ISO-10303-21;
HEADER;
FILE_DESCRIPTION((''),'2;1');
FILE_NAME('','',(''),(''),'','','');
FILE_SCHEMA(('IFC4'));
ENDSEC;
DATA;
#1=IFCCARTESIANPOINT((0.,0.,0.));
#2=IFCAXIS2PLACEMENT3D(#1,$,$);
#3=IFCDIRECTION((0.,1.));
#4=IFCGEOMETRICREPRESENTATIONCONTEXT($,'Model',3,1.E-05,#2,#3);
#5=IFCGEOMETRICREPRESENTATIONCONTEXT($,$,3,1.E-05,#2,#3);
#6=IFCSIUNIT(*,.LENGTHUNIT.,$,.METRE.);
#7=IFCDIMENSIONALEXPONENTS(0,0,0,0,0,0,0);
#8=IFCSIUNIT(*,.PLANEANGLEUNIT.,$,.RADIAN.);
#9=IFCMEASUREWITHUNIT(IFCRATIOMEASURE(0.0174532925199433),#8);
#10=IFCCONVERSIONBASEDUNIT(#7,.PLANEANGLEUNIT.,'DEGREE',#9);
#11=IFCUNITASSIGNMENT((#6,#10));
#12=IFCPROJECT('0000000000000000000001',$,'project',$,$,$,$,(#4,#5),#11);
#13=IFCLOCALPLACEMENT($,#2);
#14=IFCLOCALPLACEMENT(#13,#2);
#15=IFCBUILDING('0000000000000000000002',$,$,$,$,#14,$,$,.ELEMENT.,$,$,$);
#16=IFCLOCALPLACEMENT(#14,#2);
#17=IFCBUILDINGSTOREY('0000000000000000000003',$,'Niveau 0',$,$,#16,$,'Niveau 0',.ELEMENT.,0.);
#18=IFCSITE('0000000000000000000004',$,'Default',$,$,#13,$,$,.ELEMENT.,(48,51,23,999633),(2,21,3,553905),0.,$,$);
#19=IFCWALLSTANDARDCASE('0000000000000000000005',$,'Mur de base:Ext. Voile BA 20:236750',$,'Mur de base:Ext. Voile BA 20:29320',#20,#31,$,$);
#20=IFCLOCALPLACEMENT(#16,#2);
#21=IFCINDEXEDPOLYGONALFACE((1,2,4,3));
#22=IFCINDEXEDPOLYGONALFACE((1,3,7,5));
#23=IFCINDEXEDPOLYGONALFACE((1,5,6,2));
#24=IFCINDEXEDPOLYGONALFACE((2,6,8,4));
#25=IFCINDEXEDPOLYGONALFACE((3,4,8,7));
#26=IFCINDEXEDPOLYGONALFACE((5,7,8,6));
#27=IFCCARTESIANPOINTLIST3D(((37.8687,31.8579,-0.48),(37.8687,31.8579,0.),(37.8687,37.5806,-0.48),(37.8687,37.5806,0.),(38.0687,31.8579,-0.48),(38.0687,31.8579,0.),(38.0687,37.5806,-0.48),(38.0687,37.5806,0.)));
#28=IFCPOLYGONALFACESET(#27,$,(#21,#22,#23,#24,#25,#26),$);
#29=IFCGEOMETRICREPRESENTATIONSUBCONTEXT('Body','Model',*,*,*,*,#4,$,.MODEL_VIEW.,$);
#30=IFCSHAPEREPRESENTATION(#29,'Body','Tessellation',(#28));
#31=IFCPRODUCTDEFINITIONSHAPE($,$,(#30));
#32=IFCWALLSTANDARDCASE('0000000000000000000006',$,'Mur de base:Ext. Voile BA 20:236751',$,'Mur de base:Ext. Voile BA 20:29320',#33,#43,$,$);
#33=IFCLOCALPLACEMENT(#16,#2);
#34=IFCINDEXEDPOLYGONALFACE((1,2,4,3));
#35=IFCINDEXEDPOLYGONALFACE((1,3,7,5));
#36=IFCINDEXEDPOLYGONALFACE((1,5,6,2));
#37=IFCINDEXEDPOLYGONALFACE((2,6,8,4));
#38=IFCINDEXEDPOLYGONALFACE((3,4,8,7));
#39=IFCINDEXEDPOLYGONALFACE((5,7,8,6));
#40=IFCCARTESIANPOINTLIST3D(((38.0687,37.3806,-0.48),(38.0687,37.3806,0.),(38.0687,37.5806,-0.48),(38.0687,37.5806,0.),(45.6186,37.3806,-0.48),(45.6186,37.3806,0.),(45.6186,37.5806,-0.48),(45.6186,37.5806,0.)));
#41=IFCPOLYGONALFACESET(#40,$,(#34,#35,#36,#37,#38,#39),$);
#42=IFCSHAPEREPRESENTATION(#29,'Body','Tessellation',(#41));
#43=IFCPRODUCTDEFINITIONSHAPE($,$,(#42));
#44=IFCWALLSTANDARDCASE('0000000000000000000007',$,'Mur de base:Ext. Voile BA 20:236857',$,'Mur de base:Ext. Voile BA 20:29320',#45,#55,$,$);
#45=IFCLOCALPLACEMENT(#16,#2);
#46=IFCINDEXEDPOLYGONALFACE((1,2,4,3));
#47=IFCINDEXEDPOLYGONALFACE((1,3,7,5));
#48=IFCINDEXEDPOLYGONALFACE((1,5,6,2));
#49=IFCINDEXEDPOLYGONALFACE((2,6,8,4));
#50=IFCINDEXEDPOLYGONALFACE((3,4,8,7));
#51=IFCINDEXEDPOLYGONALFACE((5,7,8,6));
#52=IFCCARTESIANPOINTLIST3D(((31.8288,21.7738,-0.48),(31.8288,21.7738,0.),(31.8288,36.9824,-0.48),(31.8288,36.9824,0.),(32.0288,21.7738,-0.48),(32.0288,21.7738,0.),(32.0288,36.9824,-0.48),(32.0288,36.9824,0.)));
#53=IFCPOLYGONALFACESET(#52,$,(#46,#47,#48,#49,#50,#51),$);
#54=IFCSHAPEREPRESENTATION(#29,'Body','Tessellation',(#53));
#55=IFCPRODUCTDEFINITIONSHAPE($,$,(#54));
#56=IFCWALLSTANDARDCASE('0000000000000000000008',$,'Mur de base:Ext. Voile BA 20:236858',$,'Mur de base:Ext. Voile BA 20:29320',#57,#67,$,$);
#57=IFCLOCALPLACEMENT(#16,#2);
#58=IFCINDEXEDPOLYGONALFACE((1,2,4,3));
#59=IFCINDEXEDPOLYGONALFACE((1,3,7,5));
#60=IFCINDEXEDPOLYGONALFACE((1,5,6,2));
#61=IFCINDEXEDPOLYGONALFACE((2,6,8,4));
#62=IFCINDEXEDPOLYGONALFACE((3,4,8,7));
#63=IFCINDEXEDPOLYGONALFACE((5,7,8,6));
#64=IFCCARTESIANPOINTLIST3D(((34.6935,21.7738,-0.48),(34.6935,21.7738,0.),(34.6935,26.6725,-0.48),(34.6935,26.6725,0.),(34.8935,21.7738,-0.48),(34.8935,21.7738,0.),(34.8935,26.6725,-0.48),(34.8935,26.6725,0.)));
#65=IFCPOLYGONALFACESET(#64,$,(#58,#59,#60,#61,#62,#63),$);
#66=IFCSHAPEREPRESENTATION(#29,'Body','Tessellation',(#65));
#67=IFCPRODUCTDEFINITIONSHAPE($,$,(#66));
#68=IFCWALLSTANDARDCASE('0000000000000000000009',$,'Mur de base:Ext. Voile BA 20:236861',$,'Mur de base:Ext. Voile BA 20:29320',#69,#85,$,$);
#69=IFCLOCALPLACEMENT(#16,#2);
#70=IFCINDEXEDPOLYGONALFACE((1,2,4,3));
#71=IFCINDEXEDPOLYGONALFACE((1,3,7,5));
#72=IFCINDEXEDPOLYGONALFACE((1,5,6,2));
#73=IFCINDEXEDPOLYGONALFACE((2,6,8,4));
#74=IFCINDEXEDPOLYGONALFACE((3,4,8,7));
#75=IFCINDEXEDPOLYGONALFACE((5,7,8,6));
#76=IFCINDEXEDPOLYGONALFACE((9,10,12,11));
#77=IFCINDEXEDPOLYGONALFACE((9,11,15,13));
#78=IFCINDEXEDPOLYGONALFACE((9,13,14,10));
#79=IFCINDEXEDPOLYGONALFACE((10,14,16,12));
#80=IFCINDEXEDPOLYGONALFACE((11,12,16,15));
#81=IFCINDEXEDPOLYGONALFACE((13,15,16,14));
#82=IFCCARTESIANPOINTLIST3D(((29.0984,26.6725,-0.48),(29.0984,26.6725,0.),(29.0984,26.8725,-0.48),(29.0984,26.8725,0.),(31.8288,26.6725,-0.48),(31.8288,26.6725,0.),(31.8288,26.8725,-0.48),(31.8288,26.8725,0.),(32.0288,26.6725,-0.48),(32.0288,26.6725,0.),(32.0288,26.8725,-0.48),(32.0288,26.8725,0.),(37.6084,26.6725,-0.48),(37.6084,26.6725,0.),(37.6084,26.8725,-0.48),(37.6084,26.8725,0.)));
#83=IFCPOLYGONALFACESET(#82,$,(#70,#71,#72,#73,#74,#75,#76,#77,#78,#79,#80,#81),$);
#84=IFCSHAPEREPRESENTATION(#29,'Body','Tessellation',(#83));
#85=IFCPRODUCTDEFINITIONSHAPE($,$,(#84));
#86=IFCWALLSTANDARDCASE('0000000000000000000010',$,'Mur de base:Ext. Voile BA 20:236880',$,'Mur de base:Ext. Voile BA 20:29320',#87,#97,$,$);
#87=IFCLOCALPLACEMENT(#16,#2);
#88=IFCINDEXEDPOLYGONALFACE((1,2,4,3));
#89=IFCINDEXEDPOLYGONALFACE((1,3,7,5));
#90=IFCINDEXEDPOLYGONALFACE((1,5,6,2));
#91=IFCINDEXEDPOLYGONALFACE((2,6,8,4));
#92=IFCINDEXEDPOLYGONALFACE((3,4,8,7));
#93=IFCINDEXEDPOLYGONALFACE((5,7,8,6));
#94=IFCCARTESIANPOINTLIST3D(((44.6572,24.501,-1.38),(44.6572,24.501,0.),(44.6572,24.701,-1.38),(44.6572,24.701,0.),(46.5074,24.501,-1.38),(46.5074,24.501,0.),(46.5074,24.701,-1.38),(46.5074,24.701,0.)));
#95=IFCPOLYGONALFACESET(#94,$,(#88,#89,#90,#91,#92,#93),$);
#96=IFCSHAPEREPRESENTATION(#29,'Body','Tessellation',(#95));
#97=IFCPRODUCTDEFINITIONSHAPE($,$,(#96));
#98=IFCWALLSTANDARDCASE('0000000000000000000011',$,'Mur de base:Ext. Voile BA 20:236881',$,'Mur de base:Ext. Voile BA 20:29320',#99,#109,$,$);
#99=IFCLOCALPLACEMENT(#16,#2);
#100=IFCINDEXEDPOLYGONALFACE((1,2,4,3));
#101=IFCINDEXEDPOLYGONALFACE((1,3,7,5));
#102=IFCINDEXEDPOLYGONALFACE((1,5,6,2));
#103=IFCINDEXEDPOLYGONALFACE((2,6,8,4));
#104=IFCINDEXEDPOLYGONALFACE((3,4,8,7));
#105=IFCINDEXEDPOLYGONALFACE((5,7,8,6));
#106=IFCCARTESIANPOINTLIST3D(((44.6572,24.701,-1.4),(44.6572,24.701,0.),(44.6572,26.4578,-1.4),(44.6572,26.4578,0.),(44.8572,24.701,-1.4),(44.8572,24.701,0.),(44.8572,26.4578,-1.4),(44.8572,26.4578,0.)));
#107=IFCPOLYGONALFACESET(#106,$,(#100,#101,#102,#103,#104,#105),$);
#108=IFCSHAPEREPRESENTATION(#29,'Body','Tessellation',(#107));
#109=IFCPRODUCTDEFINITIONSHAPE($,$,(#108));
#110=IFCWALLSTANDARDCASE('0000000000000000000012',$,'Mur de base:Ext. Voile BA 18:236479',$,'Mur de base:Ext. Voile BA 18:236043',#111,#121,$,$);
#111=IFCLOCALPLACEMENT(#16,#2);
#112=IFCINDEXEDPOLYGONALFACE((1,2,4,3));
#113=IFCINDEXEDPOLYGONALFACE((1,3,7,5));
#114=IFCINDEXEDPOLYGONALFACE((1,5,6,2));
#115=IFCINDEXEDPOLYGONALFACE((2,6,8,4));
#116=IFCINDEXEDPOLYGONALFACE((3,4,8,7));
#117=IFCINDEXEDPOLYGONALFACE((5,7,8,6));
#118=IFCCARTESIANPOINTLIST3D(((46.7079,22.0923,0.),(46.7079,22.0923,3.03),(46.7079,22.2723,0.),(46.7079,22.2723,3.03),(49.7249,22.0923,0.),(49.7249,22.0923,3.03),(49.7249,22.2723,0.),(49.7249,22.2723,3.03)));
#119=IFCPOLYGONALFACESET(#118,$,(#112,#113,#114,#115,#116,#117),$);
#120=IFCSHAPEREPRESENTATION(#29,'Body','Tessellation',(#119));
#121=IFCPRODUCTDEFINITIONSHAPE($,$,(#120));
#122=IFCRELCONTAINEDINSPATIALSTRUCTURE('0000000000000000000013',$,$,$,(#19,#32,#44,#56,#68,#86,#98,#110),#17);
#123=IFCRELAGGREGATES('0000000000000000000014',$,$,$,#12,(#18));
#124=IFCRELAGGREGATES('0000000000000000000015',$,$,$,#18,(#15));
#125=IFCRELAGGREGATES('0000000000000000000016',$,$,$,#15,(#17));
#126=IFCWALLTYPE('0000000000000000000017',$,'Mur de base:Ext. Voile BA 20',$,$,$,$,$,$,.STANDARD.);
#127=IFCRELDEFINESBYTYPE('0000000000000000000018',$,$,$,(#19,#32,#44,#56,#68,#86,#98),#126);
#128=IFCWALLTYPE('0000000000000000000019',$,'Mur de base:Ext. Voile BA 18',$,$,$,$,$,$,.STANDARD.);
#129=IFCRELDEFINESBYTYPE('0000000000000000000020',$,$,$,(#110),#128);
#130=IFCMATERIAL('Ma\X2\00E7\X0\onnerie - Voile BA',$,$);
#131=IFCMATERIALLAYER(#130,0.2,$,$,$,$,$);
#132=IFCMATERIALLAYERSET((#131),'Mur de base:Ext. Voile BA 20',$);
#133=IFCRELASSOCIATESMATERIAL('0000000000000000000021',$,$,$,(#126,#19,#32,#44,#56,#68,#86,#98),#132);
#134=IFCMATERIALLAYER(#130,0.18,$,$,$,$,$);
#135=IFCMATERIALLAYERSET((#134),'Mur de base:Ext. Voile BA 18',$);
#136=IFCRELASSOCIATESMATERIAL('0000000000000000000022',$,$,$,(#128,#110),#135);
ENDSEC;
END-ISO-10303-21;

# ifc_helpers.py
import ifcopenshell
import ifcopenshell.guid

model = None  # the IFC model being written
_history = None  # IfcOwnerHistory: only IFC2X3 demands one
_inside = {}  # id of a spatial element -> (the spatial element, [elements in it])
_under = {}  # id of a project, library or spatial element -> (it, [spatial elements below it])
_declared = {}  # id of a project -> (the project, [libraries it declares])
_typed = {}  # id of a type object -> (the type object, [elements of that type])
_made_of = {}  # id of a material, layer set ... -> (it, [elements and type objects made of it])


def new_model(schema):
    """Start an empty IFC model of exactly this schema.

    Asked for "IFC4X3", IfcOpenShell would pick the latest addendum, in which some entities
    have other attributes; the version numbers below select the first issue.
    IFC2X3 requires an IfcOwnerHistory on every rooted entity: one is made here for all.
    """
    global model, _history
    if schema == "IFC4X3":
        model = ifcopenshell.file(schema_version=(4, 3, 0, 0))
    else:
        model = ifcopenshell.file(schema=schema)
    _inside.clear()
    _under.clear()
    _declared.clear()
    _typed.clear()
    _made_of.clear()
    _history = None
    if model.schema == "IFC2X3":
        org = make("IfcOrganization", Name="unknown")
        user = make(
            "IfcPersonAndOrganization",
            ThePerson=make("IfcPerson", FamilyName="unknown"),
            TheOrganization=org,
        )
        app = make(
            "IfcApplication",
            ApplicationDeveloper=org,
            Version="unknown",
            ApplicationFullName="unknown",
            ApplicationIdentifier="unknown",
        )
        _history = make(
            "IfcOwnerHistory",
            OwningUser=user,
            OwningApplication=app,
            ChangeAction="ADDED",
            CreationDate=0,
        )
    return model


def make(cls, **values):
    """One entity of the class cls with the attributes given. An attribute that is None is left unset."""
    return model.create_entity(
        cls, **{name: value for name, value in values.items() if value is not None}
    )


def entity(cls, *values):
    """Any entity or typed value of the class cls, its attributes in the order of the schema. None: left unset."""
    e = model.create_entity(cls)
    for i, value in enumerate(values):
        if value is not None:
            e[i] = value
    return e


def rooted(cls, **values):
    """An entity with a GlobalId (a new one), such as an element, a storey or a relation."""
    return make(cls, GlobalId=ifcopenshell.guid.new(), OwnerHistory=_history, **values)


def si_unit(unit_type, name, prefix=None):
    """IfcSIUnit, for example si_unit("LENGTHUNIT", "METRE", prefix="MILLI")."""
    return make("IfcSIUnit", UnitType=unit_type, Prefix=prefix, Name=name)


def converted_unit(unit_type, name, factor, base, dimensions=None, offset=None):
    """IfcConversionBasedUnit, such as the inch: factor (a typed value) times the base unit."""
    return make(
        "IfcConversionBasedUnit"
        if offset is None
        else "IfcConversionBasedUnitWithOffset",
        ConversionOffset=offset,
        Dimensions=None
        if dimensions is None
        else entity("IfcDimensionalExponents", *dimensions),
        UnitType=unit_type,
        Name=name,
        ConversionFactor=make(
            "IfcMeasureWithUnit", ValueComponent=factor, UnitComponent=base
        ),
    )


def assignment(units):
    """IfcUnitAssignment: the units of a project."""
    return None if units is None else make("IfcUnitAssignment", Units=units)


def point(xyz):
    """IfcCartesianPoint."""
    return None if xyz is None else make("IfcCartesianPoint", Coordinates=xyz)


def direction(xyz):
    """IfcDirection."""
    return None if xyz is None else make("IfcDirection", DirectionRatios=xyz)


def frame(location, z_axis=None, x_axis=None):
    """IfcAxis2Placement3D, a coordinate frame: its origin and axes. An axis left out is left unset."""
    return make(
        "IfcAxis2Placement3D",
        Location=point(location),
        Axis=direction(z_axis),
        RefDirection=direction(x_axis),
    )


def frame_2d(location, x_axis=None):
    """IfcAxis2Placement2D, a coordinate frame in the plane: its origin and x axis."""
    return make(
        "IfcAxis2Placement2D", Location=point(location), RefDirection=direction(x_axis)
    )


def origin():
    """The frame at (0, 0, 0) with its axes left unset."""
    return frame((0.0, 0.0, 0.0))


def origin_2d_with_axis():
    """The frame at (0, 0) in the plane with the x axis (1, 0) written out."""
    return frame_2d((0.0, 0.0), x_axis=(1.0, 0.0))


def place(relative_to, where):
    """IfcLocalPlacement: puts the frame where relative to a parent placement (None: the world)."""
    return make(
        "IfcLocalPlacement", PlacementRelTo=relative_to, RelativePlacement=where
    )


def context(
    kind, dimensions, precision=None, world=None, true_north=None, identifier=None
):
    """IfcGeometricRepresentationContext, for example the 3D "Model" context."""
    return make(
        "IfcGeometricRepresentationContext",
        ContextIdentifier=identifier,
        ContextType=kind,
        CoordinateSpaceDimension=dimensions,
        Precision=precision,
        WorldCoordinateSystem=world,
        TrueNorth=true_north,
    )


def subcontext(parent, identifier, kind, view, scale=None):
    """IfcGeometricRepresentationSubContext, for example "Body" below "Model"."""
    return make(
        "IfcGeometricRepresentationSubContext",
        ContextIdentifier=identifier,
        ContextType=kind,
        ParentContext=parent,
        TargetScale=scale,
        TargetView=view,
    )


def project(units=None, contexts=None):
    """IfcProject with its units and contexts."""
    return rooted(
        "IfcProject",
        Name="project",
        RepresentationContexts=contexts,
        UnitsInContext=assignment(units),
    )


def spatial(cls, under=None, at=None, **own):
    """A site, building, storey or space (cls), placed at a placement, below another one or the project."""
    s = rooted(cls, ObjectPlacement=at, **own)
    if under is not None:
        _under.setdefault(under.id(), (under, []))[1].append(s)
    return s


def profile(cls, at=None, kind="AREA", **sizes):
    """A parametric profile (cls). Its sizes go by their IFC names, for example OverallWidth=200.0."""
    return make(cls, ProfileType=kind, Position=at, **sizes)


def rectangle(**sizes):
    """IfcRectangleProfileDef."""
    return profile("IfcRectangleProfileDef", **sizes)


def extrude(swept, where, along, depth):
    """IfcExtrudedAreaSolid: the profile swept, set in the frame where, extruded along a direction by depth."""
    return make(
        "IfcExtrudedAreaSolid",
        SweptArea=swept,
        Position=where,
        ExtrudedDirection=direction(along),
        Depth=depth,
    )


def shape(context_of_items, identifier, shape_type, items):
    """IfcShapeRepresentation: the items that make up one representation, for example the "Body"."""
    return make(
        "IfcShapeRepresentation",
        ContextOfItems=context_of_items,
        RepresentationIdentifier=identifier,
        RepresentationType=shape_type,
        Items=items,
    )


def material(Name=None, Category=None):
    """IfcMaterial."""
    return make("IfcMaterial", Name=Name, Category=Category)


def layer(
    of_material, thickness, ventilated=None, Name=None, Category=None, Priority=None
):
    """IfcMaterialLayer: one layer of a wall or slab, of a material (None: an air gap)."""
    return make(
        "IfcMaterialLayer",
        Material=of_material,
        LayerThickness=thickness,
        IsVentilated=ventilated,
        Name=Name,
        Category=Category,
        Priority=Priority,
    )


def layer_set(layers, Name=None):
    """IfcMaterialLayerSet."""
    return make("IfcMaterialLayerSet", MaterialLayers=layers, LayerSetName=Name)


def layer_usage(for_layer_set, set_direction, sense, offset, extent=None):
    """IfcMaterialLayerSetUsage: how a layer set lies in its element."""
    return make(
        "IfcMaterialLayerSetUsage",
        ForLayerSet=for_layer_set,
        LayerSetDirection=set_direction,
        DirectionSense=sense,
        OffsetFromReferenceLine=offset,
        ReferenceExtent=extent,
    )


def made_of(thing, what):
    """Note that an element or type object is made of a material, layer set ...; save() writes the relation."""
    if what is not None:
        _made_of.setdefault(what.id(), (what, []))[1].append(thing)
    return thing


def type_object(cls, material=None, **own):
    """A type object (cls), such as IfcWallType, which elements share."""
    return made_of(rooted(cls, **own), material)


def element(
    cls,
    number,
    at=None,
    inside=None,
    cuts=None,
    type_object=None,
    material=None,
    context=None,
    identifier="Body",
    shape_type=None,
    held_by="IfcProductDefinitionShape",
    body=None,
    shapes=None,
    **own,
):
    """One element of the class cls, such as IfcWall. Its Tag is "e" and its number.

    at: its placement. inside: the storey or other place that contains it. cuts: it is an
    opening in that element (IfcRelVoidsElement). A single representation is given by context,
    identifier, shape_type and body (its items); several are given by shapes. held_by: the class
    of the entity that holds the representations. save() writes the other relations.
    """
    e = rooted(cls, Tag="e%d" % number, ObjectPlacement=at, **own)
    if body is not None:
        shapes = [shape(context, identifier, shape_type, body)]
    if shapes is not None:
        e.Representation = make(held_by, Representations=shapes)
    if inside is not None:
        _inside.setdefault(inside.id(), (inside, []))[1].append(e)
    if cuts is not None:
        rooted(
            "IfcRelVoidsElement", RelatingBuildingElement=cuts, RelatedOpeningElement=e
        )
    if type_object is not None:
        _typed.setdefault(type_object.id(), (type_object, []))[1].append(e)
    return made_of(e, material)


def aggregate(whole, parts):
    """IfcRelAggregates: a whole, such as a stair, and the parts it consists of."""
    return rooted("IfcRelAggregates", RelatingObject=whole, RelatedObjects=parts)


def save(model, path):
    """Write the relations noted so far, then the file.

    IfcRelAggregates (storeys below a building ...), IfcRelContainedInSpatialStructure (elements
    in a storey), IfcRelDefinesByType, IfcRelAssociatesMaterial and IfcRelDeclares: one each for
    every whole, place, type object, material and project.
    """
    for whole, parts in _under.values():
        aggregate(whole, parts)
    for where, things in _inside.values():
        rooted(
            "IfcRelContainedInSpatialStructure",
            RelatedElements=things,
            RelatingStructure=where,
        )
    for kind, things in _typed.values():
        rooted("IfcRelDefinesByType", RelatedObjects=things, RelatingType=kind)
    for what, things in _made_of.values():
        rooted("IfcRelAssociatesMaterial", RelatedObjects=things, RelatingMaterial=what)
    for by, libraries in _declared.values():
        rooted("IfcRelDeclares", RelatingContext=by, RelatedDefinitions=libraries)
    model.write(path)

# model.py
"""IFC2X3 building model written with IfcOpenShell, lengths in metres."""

from ifc_helpers import new_model, entity, si_unit, converted_unit, direction, frame, frame_2d, origin, origin_2d_with_axis, place, context, subcontext, project, spatial, rectangle, extrude, material, layer, layer_set, layer_usage, type_object, element, save


model = new_model("IFC2X3")

# Units and contexts
model_context = context("Model", 3, precision=1e-05, world=origin(), true_north=direction((0.0, 1.0)))
context_of_model = context(None, 3, precision=1e-05, world=origin(), true_north=direction((0.0, 1.0)))
body_context = subcontext(model_context, "Body", "Model", "MODEL_VIEW")
ifc_project = project(units=[si_unit("LENGTHUNIT", "METRE"), converted_unit("PLANEANGLEUNIT", "DEGREE", entity("IfcRatioMeasure", 0.0174532925199433), si_unit("PLANEANGLEUNIT", "RADIAN"), dimensions=[0, 0, 0, 0, 0, 0, 0])], contexts=[model_context, context_of_model])

# Site, building, storey
site_placement = place(None, origin())
site = spatial("IfcSite", under=ifc_project, at=site_placement, Name="Default", CompositionType="ELEMENT", RefLatitude=(48, 51, 23, 999633), RefLongitude=(2, 21, 3, 553905), RefElevation=0.0)
building_placement = place(site_placement, origin())
building = spatial("IfcBuilding", under=site, at=building_placement, CompositionType="ELEMENT")
storey_placement = place(building_placement, origin())
storey = spatial("IfcBuildingStorey", under=building, at=storey_placement, Name="Niveau 0", LongName="Niveau 0", CompositionType="ELEMENT", Elevation=0.0)

# Shared definitions
ifc_material = material(Name="Maçonnerie - Voile BA")
ifc_layer_1 = layer(ifc_material, 0.2)
ifc_layer_set_1 = layer_set([ifc_layer_1], Name="Mur de base:Ext. Voile BA 20")
wall_type_1 = type_object("IfcWallType", Name="Mur de base:Ext. Voile BA 20", PredefinedType="STANDARD", material=ifc_layer_set_1)

# Walls
ifc_layer_usage_1 = layer_usage(ifc_layer_set_1, "AXIS2", "NEGATIVE", 0.1)
wall_1_placement = place(storey_placement, frame((37.9687, 31.8579, -0.48), z_axis=(0.0, 0.0, 1.0), x_axis=(0.0, 1.0, 0.0)))
element("IfcWallStandardCase", 1, at=wall_1_placement, inside=storey, type_object=wall_type_1, material=ifc_layer_usage_1, Name="Mur de base:Ext. Voile BA 20:236750", ObjectType="Mur de base:Ext. Voile BA 20:29320", context=body_context, shape_type="SweptSolid", body=[
    extrude(rectangle(XDim=5.7227, YDim=0.2, at=frame_2d((2.8613, 0.0), x_axis=(-1.0, 0.0))), origin(), (0.0, 0.0, 1.0), 0.48),
])
ifc_layer_usage_2 = layer_usage(ifc_layer_set_1, "AXIS2", "NEGATIVE", 0.1)
wall_2_placement = place(storey_placement, frame((38.0687, 37.4806, -0.48)))
element("IfcWallStandardCase", 2, at=wall_2_placement, inside=storey, type_object=wall_type_1, material=ifc_layer_usage_2, Name="Mur de base:Ext. Voile BA 20:236751", ObjectType="Mur de base:Ext. Voile BA 20:29320", context=body_context, shape_type="SweptSolid", body=[
    extrude(rectangle(XDim=7.55, YDim=0.2, at=frame_2d((3.775, 0.0), x_axis=(-1.0, 0.0))), origin(), (0.0, 0.0, 1.0), 0.48),
])
ifc_layer_usage_3 = layer_usage(ifc_layer_set_1, "AXIS2", "NEGATIVE", 0.1)
wall_3_placement = place(storey_placement, frame((31.9288, 36.9824, -0.48), z_axis=(0.0, 0.0, 1.0), x_axis=(0.0, -1.0, 0.0)))
element("IfcWallStandardCase", 3, at=wall_3_placement, inside=storey, type_object=wall_type_1, material=ifc_layer_usage_3, Name="Mur de base:Ext. Voile BA 20:236857", ObjectType="Mur de base:Ext. Voile BA 20:29320", context=body_context, shape_type="SweptSolid", body=[
    extrude(rectangle(XDim=15.2086, YDim=0.2, at=frame_2d((7.6043, 0.0), x_axis=(-1.0, 0.0))), origin(), (0.0, 0.0, 1.0), 0.48),
])
ifc_layer_usage_4 = layer_usage(ifc_layer_set_1, "AXIS2", "NEGATIVE", 0.1)
wall_4_placement = place(storey_placement, frame((34.7935, 26.6725, -0.48), z_axis=(0.0, 0.0, 1.0), x_axis=(0.0, -1.0, 0.0)))
element("IfcWallStandardCase", 4, at=wall_4_placement, inside=storey, type_object=wall_type_1, material=ifc_layer_usage_4, Name="Mur de base:Ext. Voile BA 20:236858", ObjectType="Mur de base:Ext. Voile BA 20:29320", context=body_context, shape_type="SweptSolid", body=[
    extrude(rectangle(XDim=4.8986, YDim=0.2, at=frame_2d((2.4493, 0.0), x_axis=(-1.0, 0.0))), origin(), (0.0, 0.0, 1.0), 0.48),
])

# Wall, opening
ifc_layer_usage_5 = layer_usage(ifc_layer_set_1, "AXIS2", "NEGATIVE", 0.1)
wall_5_placement = place(storey_placement, frame((29.0984, 26.7725, -0.48)))
wall_5 = element("IfcWallStandardCase", 5, at=wall_5_placement, inside=storey, type_object=wall_type_1, material=ifc_layer_usage_5, Name="Mur de base:Ext. Voile BA 20:236861", ObjectType="Mur de base:Ext. Voile BA 20:29320", context=body_context, shape_type="SweptSolid", body=[
    extrude(rectangle(XDim=8.51, YDim=0.2, at=frame_2d((4.255, 0.0), x_axis=(-1.0, 0.0))), origin(), (0.0, 0.0, 1.0), 0.48),
])
opening_1_placement = place(storey_placement, frame((29.0984, 26.7725, -0.48)))
element("IfcOpeningElement", 6, at=opening_1_placement, cuts=wall_5, ObjectType="Opening", context=body_context, shape_type="SweptSolid", body=[
    extrude(rectangle(XDim=0.48, YDim=0.2, at=origin_2d_with_axis()), frame((2.7304, 0.0, 0.24), z_axis=(1.0, 0.0, 0.0), x_axis=(0.0, 0.0, -1.0)), (0.0, 0.0, 1.0), 0.2),
])

# Walls
ifc_layer_usage_6 = layer_usage(ifc_layer_set_1, "AXIS2", "NEGATIVE", 0.1)
wall_6_placement = place(storey_placement, frame((46.5074, 24.601, -1.38), z_axis=(0.0, 0.0, 1.0), x_axis=(-1.0, 0.0, 0.0)))
element("IfcWallStandardCase", 7, at=wall_6_placement, inside=storey, type_object=wall_type_1, material=ifc_layer_usage_6, Name="Mur de base:Ext. Voile BA 20:236880", ObjectType="Mur de base:Ext. Voile BA 20:29320", context=body_context, shape_type="SweptSolid", body=[
    extrude(rectangle(XDim=1.8501, YDim=0.2, at=frame_2d((0.9251, 0.0), x_axis=(-1.0, 0.0))), origin(), (0.0, 0.0, 1.0), 1.38),
])
ifc_layer_usage_7 = layer_usage(ifc_layer_set_1, "AXIS2", "NEGATIVE", 0.1)
wall_7_placement = place(storey_placement, frame((44.7572, 24.701, -1.4), z_axis=(0.0, 0.0, 1.0), x_axis=(0.0, 1.0, 0.0)))
element("IfcWallStandardCase", 8, at=wall_7_placement, inside=storey, type_object=wall_type_1, material=ifc_layer_usage_7, Name="Mur de base:Ext. Voile BA 20:236881", ObjectType="Mur de base:Ext. Voile BA 20:29320", context=body_context, shape_type="SweptSolid", body=[
    extrude(rectangle(XDim=1.7568, YDim=0.2, at=frame_2d((0.8784, 0.0), x_axis=(-1.0, 0.0))), origin(), (0.0, 0.0, 1.0), 1.4),
])
ifc_layer_2 = layer(ifc_material, 0.18)
ifc_layer_set_2 = layer_set([ifc_layer_2], Name="Mur de base:Ext. Voile BA 18")
ifc_layer_usage_8 = layer_usage(ifc_layer_set_2, "AXIS2", "NEGATIVE", 0.09)
wall_type_2 = type_object("IfcWallType", Name="Mur de base:Ext. Voile BA 18", PredefinedType="STANDARD", material=ifc_layer_set_2)
wall_8_placement = place(storey_placement, frame((49.7249, 22.1823, 0.0), z_axis=(0.0, 0.0, 1.0), x_axis=(-1.0, 0.0, 0.0)))
element("IfcWallStandardCase", 9, at=wall_8_placement, inside=storey, type_object=wall_type_2, material=ifc_layer_usage_8, Name="Mur de base:Ext. Voile BA 18:236479", ObjectType="Mur de base:Ext. Voile BA 18:236043", context=body_context, shape_type="SweptSolid", body=[
    extrude(rectangle(XDim=3.017, YDim=0.18, at=frame_2d((1.5085, 0.0), x_axis=(-1.0, 0.0))), origin(), (0.0, 0.0, 1.0), 3.03),
])

save(model, "model.ifc")
